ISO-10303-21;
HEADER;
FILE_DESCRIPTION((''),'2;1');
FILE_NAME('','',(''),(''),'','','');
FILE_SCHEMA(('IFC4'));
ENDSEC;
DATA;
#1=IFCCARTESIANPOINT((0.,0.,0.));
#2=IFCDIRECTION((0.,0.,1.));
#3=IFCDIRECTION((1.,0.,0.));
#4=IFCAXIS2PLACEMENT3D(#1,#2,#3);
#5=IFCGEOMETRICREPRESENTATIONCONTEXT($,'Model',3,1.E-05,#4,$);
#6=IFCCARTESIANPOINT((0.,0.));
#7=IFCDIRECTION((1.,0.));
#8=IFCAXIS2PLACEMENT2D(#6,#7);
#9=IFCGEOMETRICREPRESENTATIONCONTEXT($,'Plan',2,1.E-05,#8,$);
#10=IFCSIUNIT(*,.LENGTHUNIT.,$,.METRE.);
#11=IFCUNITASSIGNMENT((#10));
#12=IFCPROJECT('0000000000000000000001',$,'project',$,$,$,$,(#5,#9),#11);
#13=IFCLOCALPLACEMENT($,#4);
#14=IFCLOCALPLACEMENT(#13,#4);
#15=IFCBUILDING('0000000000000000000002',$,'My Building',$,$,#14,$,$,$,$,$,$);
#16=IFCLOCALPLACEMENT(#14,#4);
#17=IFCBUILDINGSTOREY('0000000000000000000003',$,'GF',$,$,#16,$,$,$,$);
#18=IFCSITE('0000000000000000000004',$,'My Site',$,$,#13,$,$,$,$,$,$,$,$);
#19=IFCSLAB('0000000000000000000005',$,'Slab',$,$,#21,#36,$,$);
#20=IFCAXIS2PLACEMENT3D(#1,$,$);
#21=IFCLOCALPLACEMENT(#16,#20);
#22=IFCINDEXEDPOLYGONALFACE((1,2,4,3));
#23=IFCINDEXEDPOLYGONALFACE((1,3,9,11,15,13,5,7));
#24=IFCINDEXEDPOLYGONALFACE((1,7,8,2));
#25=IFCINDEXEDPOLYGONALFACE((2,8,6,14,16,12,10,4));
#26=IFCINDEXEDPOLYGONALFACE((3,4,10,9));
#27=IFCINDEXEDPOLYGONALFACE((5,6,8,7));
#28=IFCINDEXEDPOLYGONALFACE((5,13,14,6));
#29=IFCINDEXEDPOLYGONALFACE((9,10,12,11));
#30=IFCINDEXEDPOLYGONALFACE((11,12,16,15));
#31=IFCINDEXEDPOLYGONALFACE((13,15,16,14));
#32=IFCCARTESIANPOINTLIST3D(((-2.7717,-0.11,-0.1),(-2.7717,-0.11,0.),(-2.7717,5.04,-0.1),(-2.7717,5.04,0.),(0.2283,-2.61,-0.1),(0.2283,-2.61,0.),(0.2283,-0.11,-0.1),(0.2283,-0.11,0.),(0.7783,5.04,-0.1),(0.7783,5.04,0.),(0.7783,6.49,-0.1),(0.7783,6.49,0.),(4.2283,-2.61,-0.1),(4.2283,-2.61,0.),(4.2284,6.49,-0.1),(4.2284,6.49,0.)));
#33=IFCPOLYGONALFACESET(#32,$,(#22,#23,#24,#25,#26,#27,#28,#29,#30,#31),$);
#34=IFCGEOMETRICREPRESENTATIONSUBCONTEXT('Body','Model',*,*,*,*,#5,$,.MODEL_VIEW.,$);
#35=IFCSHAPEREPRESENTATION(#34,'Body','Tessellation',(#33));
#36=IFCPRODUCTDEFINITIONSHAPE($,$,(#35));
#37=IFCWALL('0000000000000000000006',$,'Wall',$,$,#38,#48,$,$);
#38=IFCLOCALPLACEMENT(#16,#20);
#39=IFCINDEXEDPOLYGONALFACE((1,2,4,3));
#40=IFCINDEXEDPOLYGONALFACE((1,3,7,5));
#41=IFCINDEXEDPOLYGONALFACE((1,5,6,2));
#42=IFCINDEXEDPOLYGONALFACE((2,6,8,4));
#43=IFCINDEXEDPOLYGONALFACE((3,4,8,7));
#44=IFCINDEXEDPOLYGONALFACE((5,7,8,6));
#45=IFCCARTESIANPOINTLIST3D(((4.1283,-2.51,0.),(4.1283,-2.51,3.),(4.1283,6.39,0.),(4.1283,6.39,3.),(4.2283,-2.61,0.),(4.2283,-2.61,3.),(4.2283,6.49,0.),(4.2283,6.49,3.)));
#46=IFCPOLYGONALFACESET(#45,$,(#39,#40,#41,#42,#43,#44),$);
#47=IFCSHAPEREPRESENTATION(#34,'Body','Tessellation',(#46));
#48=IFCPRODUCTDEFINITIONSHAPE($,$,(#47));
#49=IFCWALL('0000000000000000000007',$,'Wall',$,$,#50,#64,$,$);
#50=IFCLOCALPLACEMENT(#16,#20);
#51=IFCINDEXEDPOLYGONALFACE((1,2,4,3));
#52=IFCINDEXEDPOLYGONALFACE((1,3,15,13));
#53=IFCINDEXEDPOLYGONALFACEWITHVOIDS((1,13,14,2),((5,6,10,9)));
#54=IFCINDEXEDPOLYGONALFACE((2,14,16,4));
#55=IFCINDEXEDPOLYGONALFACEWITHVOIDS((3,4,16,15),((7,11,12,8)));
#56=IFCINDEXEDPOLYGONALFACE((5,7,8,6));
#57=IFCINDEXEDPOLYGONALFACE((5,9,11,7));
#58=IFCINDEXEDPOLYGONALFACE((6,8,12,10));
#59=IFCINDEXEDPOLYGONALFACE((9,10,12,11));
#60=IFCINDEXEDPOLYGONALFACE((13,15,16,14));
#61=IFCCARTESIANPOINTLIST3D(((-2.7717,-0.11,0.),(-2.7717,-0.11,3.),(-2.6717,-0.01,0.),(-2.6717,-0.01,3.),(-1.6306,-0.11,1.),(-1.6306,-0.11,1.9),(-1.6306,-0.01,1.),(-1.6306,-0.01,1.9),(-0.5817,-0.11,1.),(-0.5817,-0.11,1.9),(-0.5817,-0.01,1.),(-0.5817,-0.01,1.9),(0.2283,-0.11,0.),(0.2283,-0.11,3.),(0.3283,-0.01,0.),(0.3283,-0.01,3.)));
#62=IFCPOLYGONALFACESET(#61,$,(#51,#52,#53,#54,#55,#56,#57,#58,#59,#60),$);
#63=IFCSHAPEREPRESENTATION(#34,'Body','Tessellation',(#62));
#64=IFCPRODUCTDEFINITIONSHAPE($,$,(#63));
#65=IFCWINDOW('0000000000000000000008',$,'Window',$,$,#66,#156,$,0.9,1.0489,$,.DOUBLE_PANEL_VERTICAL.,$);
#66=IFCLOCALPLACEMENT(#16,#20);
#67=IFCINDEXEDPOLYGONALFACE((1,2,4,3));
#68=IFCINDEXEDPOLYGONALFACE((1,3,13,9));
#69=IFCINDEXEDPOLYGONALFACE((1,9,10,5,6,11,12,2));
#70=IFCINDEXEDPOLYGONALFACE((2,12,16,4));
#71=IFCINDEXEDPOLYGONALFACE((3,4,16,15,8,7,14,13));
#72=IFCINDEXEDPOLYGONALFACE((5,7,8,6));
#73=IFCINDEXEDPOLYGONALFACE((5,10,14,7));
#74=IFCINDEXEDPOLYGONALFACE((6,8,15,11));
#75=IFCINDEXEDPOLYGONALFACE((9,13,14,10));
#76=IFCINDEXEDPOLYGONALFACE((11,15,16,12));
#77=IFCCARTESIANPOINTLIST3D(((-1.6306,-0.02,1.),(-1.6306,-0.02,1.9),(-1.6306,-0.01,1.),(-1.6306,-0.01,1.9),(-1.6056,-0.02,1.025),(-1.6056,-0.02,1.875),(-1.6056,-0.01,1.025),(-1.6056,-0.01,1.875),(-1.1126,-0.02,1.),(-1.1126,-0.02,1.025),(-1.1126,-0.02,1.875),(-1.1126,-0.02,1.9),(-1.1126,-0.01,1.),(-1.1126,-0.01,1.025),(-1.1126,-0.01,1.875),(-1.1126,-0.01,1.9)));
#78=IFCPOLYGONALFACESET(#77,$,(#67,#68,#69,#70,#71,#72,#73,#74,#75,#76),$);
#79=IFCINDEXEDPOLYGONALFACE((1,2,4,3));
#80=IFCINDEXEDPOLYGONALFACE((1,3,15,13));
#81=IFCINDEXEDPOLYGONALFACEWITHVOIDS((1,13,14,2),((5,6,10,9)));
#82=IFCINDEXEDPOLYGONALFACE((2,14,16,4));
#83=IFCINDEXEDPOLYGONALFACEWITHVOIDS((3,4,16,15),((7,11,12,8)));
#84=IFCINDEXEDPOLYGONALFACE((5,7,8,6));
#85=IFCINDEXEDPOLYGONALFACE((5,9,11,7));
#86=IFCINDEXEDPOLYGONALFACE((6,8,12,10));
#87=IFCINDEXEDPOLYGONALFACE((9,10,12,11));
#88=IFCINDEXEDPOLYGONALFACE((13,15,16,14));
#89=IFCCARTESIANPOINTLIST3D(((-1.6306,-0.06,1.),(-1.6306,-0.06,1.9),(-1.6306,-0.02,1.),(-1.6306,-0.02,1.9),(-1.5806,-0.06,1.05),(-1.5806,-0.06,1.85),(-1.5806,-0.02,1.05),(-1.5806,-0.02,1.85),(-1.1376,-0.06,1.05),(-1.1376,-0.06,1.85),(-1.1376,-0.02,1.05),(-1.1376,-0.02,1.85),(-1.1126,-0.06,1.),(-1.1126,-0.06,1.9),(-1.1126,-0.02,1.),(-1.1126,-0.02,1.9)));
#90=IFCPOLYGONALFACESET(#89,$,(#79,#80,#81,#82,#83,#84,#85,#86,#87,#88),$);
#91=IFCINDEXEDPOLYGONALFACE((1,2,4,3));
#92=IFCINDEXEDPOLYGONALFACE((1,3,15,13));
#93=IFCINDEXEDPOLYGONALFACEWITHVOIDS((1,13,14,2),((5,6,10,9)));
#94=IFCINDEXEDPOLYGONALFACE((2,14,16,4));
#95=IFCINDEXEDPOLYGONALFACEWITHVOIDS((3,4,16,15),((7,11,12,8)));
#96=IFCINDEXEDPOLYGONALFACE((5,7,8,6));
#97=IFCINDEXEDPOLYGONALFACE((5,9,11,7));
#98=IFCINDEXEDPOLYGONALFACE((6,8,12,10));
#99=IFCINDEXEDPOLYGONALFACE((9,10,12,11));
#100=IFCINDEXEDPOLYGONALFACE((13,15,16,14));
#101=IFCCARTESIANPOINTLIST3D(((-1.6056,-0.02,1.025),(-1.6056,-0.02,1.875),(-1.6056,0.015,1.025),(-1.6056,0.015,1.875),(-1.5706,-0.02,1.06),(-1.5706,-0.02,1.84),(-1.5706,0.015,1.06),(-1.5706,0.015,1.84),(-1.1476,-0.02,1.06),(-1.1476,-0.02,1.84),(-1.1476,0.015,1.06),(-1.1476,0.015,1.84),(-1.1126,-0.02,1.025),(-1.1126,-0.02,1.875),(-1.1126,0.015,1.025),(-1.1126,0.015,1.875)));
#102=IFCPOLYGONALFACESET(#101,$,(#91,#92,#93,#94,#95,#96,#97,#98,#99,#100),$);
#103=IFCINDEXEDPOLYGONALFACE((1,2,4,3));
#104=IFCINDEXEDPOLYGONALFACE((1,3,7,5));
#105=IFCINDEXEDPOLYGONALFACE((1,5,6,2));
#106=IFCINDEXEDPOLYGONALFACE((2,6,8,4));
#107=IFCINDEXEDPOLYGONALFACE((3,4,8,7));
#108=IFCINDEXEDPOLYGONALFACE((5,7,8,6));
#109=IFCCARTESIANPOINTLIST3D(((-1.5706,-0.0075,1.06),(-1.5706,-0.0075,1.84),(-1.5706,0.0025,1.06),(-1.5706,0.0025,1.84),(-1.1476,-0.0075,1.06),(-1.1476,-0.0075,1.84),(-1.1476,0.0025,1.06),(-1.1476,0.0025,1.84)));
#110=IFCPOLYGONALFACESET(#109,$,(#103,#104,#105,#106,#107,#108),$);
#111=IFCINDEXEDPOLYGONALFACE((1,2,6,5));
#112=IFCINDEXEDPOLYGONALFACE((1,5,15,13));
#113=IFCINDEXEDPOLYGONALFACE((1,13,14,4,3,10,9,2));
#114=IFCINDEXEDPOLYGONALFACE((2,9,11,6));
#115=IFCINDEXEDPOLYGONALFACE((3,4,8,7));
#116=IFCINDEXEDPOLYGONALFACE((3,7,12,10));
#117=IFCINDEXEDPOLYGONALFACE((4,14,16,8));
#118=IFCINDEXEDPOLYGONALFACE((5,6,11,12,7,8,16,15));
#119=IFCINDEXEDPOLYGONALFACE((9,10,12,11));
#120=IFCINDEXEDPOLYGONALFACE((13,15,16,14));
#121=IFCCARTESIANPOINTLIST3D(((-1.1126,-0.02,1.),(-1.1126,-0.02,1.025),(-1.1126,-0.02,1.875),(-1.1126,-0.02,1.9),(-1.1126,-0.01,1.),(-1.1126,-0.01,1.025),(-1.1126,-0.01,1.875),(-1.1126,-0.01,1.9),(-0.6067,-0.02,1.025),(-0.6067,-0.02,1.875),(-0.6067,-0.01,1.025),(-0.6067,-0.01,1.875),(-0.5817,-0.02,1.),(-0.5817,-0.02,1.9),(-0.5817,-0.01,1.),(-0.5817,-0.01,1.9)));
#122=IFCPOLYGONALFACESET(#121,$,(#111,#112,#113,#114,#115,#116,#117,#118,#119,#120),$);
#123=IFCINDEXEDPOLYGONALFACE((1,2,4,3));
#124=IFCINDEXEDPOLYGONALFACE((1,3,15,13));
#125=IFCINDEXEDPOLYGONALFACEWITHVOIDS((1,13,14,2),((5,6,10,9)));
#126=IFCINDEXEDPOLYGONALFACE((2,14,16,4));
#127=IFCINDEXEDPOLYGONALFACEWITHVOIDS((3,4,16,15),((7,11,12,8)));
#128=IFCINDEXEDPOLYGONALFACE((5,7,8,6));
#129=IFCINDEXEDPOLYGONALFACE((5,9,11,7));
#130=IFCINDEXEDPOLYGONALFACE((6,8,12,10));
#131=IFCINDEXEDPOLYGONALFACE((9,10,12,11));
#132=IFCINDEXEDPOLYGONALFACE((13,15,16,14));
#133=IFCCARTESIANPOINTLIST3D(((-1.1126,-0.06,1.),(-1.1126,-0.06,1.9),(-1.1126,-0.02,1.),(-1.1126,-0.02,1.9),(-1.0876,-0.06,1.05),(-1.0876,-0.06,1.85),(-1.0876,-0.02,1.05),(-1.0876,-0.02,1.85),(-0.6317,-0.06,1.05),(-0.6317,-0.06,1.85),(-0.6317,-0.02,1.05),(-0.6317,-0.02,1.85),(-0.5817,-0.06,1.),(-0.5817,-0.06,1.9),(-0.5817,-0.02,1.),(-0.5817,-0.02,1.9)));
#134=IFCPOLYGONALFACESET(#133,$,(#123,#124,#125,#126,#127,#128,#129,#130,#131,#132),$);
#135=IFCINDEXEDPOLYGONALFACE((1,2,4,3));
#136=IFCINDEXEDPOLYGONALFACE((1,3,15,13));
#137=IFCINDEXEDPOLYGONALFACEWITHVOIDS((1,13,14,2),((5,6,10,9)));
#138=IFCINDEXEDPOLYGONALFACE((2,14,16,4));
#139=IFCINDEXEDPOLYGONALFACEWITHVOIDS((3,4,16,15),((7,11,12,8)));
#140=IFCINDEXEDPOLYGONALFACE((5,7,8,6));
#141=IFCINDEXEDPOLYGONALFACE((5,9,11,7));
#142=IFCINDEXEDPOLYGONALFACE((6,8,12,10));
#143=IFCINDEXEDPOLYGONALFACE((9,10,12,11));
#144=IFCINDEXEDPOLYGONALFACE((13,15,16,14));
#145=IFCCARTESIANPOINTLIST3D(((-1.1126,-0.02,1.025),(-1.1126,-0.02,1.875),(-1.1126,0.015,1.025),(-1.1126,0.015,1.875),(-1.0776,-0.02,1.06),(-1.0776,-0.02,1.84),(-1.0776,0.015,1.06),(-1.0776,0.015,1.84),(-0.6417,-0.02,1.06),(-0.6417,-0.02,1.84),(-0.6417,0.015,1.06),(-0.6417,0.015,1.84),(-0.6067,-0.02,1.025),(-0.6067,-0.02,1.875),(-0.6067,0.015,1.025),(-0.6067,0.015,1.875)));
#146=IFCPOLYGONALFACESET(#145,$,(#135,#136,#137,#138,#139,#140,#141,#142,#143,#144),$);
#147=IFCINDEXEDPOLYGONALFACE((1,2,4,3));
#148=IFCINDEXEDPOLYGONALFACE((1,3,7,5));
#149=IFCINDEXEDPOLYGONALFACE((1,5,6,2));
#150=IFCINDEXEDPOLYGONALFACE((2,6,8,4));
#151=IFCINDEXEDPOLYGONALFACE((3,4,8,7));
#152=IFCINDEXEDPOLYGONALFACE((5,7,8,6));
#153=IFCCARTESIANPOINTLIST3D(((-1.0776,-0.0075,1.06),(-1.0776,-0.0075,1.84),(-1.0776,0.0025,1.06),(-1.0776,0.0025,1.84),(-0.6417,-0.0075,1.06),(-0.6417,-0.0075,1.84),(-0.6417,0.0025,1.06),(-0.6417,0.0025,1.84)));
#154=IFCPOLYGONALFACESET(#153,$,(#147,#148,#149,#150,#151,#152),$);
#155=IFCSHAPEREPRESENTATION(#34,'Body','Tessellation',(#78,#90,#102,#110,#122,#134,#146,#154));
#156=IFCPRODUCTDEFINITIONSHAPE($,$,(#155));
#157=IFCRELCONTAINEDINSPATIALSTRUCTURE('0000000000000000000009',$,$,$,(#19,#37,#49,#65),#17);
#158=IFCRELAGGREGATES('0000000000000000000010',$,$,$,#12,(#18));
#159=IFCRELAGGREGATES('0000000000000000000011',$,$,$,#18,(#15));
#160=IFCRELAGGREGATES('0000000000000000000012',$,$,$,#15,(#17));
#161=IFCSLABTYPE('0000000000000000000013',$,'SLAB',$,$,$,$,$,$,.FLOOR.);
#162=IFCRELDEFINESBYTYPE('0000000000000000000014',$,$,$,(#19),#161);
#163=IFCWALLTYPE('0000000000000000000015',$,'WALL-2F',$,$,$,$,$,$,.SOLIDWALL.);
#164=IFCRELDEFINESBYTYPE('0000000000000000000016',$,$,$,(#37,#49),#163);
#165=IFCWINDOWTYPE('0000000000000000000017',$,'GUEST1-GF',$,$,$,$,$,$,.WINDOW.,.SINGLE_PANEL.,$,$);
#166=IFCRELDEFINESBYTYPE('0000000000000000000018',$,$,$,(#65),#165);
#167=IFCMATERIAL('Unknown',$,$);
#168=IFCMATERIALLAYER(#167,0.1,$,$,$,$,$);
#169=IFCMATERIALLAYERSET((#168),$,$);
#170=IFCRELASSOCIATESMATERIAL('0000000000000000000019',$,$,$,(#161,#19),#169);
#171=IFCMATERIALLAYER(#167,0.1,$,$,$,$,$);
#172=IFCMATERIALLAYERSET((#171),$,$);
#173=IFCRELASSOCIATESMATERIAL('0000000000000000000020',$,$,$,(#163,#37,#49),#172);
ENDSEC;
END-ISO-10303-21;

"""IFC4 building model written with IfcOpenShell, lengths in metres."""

from ifc_helpers import new_model, entity, si_unit, frame, origin_with_axes, origin_2d_with_axis, place, context, subcontext, project, spatial, line, indexed_curve, outline, extrude, shape, source, transform, mapped, material, layer, layer_set, layer_usage, type_object, type_shapes, element, fill, save


model = new_model("IFC4")

# Units and contexts
model_context = context("Model", 3, precision=1e-05, world=origin_with_axes())
plan_context = context("Plan", 2, precision=1e-05, world=origin_2d_with_axis())
body_context_1 = subcontext(model_context, "Body", "Model", "MODEL_VIEW")
body_context_2 = subcontext(plan_context, "Body", "Plan", "PLAN_VIEW")
ifc_project = project(units=[si_unit("LENGTHUNIT", "METRE")], contexts=[model_context, plan_context])

# Site, building, storey
site_placement = place(None, origin_with_axes())
site = spatial("IfcSite", under=ifc_project, at=site_placement, Name="My Site")
building_placement = place(site_placement, origin_with_axes())
building = spatial("IfcBuilding", under=site, at=building_placement, Name="My Building")
storey_placement = place(building_placement, origin_with_axes())
storey = spatial("IfcBuildingStorey", under=building, at=storey_placement, Name="GF")

# Slab
ifc_material = material(Name="Unknown")
ifc_layer_1 = layer(ifc_material, 0.1)
ifc_layer_set_1 = layer_set([ifc_layer_1])
ifc_layer_usage_1 = layer_usage(ifc_layer_set_1, "AXIS3", "POSITIVE", -0.1)
slab_type = type_object("IfcSlabType", Name="SLAB", PredefinedType="FLOOR", material=ifc_layer_set_1)
slab_placement = place(storey_placement, frame((4.2283, -2.61, 0.0), z_axis=(0.0, 0.0, 1.0), x_axis=(1.0, 0.0, 0.0)))
element("IfcSlab", 1, at=slab_placement, inside=storey, type_object=slab_type, material=ifc_layer_usage_1, Name="Slab", context=body_context_1, shape_type="SweptSolid", body=[
    extrude(outline(indexed_curve([(0.0, 0.0), (0.0, 9.1), (-3.45, 9.1), (-3.45, 7.65), (-7.0, 7.65), (-7.0, 2.5), (-4.0, 2.5), (-4.0, 0.0), (0.0, 0.0)])), frame((0.0, 0.0, -0.1), z_axis=(0.0, 0.0, 1.0), x_axis=(1.0, 0.0, 0.0)), (0.0, 0.0, 1.0), 0.1),
])

# Shared definitions
ifc_layer_2 = layer(ifc_material, 0.1)
ifc_layer_set_2 = layer_set([ifc_layer_2])
wall_type = type_object("IfcWallType", Name="WALL-2F", PredefinedType="SOLIDWALL", material=ifc_layer_set_2)

# Wall
ifc_layer_usage_2 = layer_usage(ifc_layer_set_2, "AXIS2", "POSITIVE", 0.0)
wall_1_placement = place(storey_placement, frame((4.2283, -2.61, 0.0), z_axis=(0.0, 0.0, 1.0), x_axis=(0.0, 1.0, 0.0)))
element("IfcWall", 2, at=wall_1_placement, inside=storey, type_object=wall_type, material=ifc_layer_usage_2, Name="Wall", context=body_context_1, shape_type="SweptSolid", body=[
    extrude(outline(indexed_curve([(0.0, 0.0), (0.1, 0.1), (9.0, 0.1), (9.1, 0.0)], segments=[line(1, 2, 3, 4, 1)])), origin_with_axes(), (0.0, 0.0, 1.0), 3.0),
])

# Wall, opening, window
ifc_layer_usage_3 = layer_usage(ifc_layer_set_2, "AXIS2", "POSITIVE", 0.0)
wall_2_placement = place(storey_placement, frame((-2.7717, -0.11, 0.0), z_axis=(0.0, 0.0, 1.0), x_axis=(1.0, 0.0, 0.0)))
wall_2 = element("IfcWall", 3, at=wall_2_placement, inside=storey, type_object=wall_type, material=ifc_layer_usage_3, Name="Wall", context=body_context_1, shape_type="SweptSolid", body=[
    extrude(outline(indexed_curve([(0.0, 0.0), (0.1, 0.1), (3.1, 0.1), (3.0, 0.0)], segments=[line(1, 2, 3, 4, 1)])), origin_with_axes(), (0.0, 0.0, 1.0), 3.0),
])
shared_shape_1 = source(origin_with_axes(), body_context_1, "Body", "SweptSolid", [
    extrude(outline(indexed_curve([(0.0, 0.0), (1.0489, 0.0), (1.0489, 0.9), (0.0, 0.9)], segments=[line(1, 2, 3, 4, 1)])), frame((0.0, -0.6, 0.0), z_axis=(0.0, -1.0, 0.0), x_axis=(1.0, 0.0, 0.0)), (0.0, 0.0, -1.0), 1.2),
])
opening_1_placement = place(wall_2_placement, frame((1.141, 0.0, 1.0), z_axis=(0.0, 0.0, 1.0), x_axis=(1.0, 0.0, 0.0)))
opening_1 = element("IfcOpeningElement", 4, at=opening_1_placement, cuts=wall_2, PredefinedType="OPENING", context=body_context_1, shape_type="MappedRepresentation", body=[
    mapped(shared_shape_1, transform((0.0, 0.0, 0.0), x_axis=(1.0, 0.0, 0.0), y_axis=(0.0, 1.0, 0.0), z_axis=(0.0, 0.0, 1.0), scale=1.0)),
])
window_type_1 = type_object("IfcWindowType", Name="GUEST1-GF", PartitioningType="SINGLE_PANEL", PredefinedType="WINDOW")
shared_shape_2 = source(origin_with_axes(), body_context_1, "Body", "SweptSolid", [
    extrude(outline(indexed_curve([(0.5181, 0.0), (0.0, 0.0), (0.0, 0.9), (0.5181, 0.9), (0.5181, 0.875), (0.025, 0.875), (0.025, 0.025), (0.5181, 0.025)], segments=[line(1, 2, 3, 4, 5, 6, 7, 8, 1)])), frame((0.0, 0.09, 0.0), z_axis=(0.0, -1.0, 0.0), x_axis=(1.0, 0.0, 0.0)), (0.0, 0.0, -1.0), 0.01),
    extrude(outline(indexed_curve([(0.0, 0.0), (0.5181, 0.0), (0.5181, 0.9), (0.0, 0.9)], segments=[line(1, 2, 3, 4, 1)]), holes=[indexed_curve([(0.05, 0.05), (0.4931, 0.05), (0.4931, 0.85), (0.05, 0.85)], segments=[line(1, 2, 3, 4, 1)])]), frame((0.0, 0.05, 0.0), z_axis=(0.0, -1.0, 0.0), x_axis=(1.0, 0.0, 0.0)), (0.0, 0.0, -1.0), 0.04),
    extrude(outline(indexed_curve([(0.0, 0.0), (0.4931, 0.0), (0.4931, 0.85), (0.0, 0.85)], segments=[line(1, 2, 3, 4, 1)]), holes=[indexed_curve([(0.035, 0.035), (0.4581, 0.035), (0.4581, 0.815), (0.035, 0.815)], segments=[line(1, 2, 3, 4, 1)])]), frame((0.025, 0.09, 0.025), z_axis=(0.0, -1.0, 0.0), x_axis=(1.0, 0.0, 0.0)), (0.0, 0.0, -1.0), 0.035),
    extrude(outline(indexed_curve([(0.035, 0.035), (0.4581, 0.035), (0.4581, 0.815), (0.035, 0.815)], segments=[line(1, 2, 3, 4, 1)])), frame((0.025, 0.1025, 0.025), z_axis=(0.0, -1.0, 0.0), x_axis=(1.0, 0.0, 0.0)), (0.0, 0.0, -1.0), 0.01),
    extrude(outline(indexed_curve([(0.0, 0.9), (0.5308, 0.9), (0.5308, 0.0), (0.0, 0.0), (0.0, 0.025), (0.5058, 0.025), (0.5058, 0.875), (0.0, 0.875)], segments=[line(1, 2, 3, 4, 5, 6, 7, 8, 1)])), frame((0.5181, 0.09, 0.0), z_axis=(0.0, -1.0, 0.0), x_axis=(1.0, 0.0, 0.0)), (0.0, 0.0, -1.0), 0.01),
    extrude(outline(indexed_curve([(0.0, 0.0), (0.5308, 0.0), (0.5308, 0.9), (0.0, 0.9)], segments=[line(1, 2, 3, 4, 1)]), holes=[indexed_curve([(0.025, 0.05), (0.4808, 0.05), (0.4808, 0.85), (0.025, 0.85)], segments=[line(1, 2, 3, 4, 1)])]), frame((0.5181, 0.05, 0.0), z_axis=(0.0, -1.0, 0.0), x_axis=(1.0, 0.0, 0.0)), (0.0, 0.0, -1.0), 0.04),
    extrude(outline(indexed_curve([(0.0, 0.0), (0.5058, 0.0), (0.5058, 0.85), (0.0, 0.85)], segments=[line(1, 2, 3, 4, 1)]), holes=[indexed_curve([(0.035, 0.035), (0.4708, 0.035), (0.4708, 0.815), (0.035, 0.815)], segments=[line(1, 2, 3, 4, 1)])]), frame((0.5181, 0.09, 0.025), z_axis=(0.0, -1.0, 0.0), x_axis=(1.0, 0.0, 0.0)), (0.0, 0.0, -1.0), 0.035),
    extrude(outline(indexed_curve([(0.035, 0.035), (0.4708, 0.035), (0.4708, 0.815), (0.035, 0.815)], segments=[line(1, 2, 3, 4, 1)])), frame((0.5181, 0.1025, 0.025), z_axis=(0.0, -1.0, 0.0), x_axis=(1.0, 0.0, 0.0)), (0.0, 0.0, -1.0), 0.01),
])
shared_shape_3 = source(origin_with_axes(), body_context_2, "Body", "Curve2D", [
    entity("IfcIndexedPolyCurve", entity("IfcCartesianPointList2D", [[0.05, 0.05], [0.4931, 0.05]])),
    entity("IfcIndexedPolyCurve", entity("IfcCartesianPointList2D", [[0.0, 0.1], [0.025, 0.1], [0.025, 0.09], [0.05, 0.09], [0.05, 0.05], [0.0, 0.05]]), [entity("IfcLineIndex", [1, 2, 3, 4, 5, 6, 1])]),
    entity("IfcIndexedPolyCurve", entity("IfcCartesianPointList2D", [[0.5181, 0.1], [0.5181, 0.1], [0.5181, 0.09], [0.4931, 0.09], [0.4931, 0.05], [0.5181, 0.05]])),
    entity("IfcIndexedPolyCurve", entity("IfcCartesianPointList2D", [[0.025, 0.09], [0.06, 0.09], [0.06, 0.125], [0.025, 0.125]]), [entity("IfcLineIndex", [1, 2, 3, 4, 1])]),
    entity("IfcIndexedPolyCurve", entity("IfcCartesianPointList2D", [[0.5181, 0.09], [0.4831, 0.09], [0.4831, 0.125], [0.5181, 0.125]]), [entity("IfcLineIndex", [1, 2, 3, 4, 1])]),
    entity("IfcIndexedPolyCurve", entity("IfcCartesianPointList2D", [[0.06, 0.09], [0.4831, 0.09]])),
    entity("IfcIndexedPolyCurve", entity("IfcCartesianPointList2D", [[0.06, 0.125], [0.4831, 0.125]])),
    entity("IfcIndexedPolyCurve", entity("IfcCartesianPointList2D", [[0.06, 0.1075], [0.4831, 0.1075]])),
    entity("IfcIndexedPolyCurve", entity("IfcCartesianPointList2D", [[0.5431, 0.05], [0.9989, 0.05]])),
    entity("IfcIndexedPolyCurve", entity("IfcCartesianPointList2D", [[0.5181, 0.1], [0.5181, 0.1], [0.5181, 0.09], [0.5431, 0.09], [0.5431, 0.05], [0.5181, 0.05]])),
    entity("IfcIndexedPolyCurve", entity("IfcCartesianPointList2D", [[1.0489, 0.1], [1.0239, 0.1], [1.0239, 0.09], [0.9989, 0.09], [0.9989, 0.05], [1.0489, 0.05]]), [entity("IfcLineIndex", [1, 2, 3, 4, 5, 6, 1])]),
    entity("IfcIndexedPolyCurve", entity("IfcCartesianPointList2D", [[0.5181, 0.09], [0.5531, 0.09], [0.5531, 0.125], [0.5181, 0.125]]), [entity("IfcLineIndex", [1, 2, 3, 4, 1])]),
    entity("IfcIndexedPolyCurve", entity("IfcCartesianPointList2D", [[1.0239, 0.09], [0.9889, 0.09], [0.9889, 0.125], [1.0239, 0.125]]), [entity("IfcLineIndex", [1, 2, 3, 4, 1])]),
    entity("IfcIndexedPolyCurve", entity("IfcCartesianPointList2D", [[0.5531, 0.09], [0.9889, 0.09]])),
    entity("IfcIndexedPolyCurve", entity("IfcCartesianPointList2D", [[0.5531, 0.125], [0.9889, 0.125]])),
    entity("IfcIndexedPolyCurve", entity("IfcCartesianPointList2D", [[0.5531, 0.1075], [0.9889, 0.1075]])),
])
type_shapes(window_type_1, [shared_shape_2, shared_shape_3])
window_1_placement = place(opening_1_placement, origin_with_axes())
window_1 = element("IfcWindow", 5, at=window_1_placement, inside=storey, type_object=window_type_1, Name="Window", OverallHeight=0.9, OverallWidth=1.0489, PartitioningType="DOUBLE_PANEL_VERTICAL", shapes=[
    shape(body_context_1, "Body", "MappedRepresentation", [mapped(shared_shape_2, transform((0.0, 0.0, 0.0), x_axis=(1.0, 0.0, 0.0), y_axis=(0.0, 1.0, 0.0), z_axis=(0.0, 0.0, 1.0), scale=1.0))]),
    shape(body_context_2, "Body", "MappedRepresentation", [mapped(shared_shape_3, transform((0.0, 0.0, 0.0), x_axis=(1.0, 0.0, 0.0), y_axis=(0.0, 1.0, 0.0), z_axis=(0.0, 0.0, 1.0), scale=1.0))]),
])
fill(opening_1, window_1)

save(model, "model.ifc")
